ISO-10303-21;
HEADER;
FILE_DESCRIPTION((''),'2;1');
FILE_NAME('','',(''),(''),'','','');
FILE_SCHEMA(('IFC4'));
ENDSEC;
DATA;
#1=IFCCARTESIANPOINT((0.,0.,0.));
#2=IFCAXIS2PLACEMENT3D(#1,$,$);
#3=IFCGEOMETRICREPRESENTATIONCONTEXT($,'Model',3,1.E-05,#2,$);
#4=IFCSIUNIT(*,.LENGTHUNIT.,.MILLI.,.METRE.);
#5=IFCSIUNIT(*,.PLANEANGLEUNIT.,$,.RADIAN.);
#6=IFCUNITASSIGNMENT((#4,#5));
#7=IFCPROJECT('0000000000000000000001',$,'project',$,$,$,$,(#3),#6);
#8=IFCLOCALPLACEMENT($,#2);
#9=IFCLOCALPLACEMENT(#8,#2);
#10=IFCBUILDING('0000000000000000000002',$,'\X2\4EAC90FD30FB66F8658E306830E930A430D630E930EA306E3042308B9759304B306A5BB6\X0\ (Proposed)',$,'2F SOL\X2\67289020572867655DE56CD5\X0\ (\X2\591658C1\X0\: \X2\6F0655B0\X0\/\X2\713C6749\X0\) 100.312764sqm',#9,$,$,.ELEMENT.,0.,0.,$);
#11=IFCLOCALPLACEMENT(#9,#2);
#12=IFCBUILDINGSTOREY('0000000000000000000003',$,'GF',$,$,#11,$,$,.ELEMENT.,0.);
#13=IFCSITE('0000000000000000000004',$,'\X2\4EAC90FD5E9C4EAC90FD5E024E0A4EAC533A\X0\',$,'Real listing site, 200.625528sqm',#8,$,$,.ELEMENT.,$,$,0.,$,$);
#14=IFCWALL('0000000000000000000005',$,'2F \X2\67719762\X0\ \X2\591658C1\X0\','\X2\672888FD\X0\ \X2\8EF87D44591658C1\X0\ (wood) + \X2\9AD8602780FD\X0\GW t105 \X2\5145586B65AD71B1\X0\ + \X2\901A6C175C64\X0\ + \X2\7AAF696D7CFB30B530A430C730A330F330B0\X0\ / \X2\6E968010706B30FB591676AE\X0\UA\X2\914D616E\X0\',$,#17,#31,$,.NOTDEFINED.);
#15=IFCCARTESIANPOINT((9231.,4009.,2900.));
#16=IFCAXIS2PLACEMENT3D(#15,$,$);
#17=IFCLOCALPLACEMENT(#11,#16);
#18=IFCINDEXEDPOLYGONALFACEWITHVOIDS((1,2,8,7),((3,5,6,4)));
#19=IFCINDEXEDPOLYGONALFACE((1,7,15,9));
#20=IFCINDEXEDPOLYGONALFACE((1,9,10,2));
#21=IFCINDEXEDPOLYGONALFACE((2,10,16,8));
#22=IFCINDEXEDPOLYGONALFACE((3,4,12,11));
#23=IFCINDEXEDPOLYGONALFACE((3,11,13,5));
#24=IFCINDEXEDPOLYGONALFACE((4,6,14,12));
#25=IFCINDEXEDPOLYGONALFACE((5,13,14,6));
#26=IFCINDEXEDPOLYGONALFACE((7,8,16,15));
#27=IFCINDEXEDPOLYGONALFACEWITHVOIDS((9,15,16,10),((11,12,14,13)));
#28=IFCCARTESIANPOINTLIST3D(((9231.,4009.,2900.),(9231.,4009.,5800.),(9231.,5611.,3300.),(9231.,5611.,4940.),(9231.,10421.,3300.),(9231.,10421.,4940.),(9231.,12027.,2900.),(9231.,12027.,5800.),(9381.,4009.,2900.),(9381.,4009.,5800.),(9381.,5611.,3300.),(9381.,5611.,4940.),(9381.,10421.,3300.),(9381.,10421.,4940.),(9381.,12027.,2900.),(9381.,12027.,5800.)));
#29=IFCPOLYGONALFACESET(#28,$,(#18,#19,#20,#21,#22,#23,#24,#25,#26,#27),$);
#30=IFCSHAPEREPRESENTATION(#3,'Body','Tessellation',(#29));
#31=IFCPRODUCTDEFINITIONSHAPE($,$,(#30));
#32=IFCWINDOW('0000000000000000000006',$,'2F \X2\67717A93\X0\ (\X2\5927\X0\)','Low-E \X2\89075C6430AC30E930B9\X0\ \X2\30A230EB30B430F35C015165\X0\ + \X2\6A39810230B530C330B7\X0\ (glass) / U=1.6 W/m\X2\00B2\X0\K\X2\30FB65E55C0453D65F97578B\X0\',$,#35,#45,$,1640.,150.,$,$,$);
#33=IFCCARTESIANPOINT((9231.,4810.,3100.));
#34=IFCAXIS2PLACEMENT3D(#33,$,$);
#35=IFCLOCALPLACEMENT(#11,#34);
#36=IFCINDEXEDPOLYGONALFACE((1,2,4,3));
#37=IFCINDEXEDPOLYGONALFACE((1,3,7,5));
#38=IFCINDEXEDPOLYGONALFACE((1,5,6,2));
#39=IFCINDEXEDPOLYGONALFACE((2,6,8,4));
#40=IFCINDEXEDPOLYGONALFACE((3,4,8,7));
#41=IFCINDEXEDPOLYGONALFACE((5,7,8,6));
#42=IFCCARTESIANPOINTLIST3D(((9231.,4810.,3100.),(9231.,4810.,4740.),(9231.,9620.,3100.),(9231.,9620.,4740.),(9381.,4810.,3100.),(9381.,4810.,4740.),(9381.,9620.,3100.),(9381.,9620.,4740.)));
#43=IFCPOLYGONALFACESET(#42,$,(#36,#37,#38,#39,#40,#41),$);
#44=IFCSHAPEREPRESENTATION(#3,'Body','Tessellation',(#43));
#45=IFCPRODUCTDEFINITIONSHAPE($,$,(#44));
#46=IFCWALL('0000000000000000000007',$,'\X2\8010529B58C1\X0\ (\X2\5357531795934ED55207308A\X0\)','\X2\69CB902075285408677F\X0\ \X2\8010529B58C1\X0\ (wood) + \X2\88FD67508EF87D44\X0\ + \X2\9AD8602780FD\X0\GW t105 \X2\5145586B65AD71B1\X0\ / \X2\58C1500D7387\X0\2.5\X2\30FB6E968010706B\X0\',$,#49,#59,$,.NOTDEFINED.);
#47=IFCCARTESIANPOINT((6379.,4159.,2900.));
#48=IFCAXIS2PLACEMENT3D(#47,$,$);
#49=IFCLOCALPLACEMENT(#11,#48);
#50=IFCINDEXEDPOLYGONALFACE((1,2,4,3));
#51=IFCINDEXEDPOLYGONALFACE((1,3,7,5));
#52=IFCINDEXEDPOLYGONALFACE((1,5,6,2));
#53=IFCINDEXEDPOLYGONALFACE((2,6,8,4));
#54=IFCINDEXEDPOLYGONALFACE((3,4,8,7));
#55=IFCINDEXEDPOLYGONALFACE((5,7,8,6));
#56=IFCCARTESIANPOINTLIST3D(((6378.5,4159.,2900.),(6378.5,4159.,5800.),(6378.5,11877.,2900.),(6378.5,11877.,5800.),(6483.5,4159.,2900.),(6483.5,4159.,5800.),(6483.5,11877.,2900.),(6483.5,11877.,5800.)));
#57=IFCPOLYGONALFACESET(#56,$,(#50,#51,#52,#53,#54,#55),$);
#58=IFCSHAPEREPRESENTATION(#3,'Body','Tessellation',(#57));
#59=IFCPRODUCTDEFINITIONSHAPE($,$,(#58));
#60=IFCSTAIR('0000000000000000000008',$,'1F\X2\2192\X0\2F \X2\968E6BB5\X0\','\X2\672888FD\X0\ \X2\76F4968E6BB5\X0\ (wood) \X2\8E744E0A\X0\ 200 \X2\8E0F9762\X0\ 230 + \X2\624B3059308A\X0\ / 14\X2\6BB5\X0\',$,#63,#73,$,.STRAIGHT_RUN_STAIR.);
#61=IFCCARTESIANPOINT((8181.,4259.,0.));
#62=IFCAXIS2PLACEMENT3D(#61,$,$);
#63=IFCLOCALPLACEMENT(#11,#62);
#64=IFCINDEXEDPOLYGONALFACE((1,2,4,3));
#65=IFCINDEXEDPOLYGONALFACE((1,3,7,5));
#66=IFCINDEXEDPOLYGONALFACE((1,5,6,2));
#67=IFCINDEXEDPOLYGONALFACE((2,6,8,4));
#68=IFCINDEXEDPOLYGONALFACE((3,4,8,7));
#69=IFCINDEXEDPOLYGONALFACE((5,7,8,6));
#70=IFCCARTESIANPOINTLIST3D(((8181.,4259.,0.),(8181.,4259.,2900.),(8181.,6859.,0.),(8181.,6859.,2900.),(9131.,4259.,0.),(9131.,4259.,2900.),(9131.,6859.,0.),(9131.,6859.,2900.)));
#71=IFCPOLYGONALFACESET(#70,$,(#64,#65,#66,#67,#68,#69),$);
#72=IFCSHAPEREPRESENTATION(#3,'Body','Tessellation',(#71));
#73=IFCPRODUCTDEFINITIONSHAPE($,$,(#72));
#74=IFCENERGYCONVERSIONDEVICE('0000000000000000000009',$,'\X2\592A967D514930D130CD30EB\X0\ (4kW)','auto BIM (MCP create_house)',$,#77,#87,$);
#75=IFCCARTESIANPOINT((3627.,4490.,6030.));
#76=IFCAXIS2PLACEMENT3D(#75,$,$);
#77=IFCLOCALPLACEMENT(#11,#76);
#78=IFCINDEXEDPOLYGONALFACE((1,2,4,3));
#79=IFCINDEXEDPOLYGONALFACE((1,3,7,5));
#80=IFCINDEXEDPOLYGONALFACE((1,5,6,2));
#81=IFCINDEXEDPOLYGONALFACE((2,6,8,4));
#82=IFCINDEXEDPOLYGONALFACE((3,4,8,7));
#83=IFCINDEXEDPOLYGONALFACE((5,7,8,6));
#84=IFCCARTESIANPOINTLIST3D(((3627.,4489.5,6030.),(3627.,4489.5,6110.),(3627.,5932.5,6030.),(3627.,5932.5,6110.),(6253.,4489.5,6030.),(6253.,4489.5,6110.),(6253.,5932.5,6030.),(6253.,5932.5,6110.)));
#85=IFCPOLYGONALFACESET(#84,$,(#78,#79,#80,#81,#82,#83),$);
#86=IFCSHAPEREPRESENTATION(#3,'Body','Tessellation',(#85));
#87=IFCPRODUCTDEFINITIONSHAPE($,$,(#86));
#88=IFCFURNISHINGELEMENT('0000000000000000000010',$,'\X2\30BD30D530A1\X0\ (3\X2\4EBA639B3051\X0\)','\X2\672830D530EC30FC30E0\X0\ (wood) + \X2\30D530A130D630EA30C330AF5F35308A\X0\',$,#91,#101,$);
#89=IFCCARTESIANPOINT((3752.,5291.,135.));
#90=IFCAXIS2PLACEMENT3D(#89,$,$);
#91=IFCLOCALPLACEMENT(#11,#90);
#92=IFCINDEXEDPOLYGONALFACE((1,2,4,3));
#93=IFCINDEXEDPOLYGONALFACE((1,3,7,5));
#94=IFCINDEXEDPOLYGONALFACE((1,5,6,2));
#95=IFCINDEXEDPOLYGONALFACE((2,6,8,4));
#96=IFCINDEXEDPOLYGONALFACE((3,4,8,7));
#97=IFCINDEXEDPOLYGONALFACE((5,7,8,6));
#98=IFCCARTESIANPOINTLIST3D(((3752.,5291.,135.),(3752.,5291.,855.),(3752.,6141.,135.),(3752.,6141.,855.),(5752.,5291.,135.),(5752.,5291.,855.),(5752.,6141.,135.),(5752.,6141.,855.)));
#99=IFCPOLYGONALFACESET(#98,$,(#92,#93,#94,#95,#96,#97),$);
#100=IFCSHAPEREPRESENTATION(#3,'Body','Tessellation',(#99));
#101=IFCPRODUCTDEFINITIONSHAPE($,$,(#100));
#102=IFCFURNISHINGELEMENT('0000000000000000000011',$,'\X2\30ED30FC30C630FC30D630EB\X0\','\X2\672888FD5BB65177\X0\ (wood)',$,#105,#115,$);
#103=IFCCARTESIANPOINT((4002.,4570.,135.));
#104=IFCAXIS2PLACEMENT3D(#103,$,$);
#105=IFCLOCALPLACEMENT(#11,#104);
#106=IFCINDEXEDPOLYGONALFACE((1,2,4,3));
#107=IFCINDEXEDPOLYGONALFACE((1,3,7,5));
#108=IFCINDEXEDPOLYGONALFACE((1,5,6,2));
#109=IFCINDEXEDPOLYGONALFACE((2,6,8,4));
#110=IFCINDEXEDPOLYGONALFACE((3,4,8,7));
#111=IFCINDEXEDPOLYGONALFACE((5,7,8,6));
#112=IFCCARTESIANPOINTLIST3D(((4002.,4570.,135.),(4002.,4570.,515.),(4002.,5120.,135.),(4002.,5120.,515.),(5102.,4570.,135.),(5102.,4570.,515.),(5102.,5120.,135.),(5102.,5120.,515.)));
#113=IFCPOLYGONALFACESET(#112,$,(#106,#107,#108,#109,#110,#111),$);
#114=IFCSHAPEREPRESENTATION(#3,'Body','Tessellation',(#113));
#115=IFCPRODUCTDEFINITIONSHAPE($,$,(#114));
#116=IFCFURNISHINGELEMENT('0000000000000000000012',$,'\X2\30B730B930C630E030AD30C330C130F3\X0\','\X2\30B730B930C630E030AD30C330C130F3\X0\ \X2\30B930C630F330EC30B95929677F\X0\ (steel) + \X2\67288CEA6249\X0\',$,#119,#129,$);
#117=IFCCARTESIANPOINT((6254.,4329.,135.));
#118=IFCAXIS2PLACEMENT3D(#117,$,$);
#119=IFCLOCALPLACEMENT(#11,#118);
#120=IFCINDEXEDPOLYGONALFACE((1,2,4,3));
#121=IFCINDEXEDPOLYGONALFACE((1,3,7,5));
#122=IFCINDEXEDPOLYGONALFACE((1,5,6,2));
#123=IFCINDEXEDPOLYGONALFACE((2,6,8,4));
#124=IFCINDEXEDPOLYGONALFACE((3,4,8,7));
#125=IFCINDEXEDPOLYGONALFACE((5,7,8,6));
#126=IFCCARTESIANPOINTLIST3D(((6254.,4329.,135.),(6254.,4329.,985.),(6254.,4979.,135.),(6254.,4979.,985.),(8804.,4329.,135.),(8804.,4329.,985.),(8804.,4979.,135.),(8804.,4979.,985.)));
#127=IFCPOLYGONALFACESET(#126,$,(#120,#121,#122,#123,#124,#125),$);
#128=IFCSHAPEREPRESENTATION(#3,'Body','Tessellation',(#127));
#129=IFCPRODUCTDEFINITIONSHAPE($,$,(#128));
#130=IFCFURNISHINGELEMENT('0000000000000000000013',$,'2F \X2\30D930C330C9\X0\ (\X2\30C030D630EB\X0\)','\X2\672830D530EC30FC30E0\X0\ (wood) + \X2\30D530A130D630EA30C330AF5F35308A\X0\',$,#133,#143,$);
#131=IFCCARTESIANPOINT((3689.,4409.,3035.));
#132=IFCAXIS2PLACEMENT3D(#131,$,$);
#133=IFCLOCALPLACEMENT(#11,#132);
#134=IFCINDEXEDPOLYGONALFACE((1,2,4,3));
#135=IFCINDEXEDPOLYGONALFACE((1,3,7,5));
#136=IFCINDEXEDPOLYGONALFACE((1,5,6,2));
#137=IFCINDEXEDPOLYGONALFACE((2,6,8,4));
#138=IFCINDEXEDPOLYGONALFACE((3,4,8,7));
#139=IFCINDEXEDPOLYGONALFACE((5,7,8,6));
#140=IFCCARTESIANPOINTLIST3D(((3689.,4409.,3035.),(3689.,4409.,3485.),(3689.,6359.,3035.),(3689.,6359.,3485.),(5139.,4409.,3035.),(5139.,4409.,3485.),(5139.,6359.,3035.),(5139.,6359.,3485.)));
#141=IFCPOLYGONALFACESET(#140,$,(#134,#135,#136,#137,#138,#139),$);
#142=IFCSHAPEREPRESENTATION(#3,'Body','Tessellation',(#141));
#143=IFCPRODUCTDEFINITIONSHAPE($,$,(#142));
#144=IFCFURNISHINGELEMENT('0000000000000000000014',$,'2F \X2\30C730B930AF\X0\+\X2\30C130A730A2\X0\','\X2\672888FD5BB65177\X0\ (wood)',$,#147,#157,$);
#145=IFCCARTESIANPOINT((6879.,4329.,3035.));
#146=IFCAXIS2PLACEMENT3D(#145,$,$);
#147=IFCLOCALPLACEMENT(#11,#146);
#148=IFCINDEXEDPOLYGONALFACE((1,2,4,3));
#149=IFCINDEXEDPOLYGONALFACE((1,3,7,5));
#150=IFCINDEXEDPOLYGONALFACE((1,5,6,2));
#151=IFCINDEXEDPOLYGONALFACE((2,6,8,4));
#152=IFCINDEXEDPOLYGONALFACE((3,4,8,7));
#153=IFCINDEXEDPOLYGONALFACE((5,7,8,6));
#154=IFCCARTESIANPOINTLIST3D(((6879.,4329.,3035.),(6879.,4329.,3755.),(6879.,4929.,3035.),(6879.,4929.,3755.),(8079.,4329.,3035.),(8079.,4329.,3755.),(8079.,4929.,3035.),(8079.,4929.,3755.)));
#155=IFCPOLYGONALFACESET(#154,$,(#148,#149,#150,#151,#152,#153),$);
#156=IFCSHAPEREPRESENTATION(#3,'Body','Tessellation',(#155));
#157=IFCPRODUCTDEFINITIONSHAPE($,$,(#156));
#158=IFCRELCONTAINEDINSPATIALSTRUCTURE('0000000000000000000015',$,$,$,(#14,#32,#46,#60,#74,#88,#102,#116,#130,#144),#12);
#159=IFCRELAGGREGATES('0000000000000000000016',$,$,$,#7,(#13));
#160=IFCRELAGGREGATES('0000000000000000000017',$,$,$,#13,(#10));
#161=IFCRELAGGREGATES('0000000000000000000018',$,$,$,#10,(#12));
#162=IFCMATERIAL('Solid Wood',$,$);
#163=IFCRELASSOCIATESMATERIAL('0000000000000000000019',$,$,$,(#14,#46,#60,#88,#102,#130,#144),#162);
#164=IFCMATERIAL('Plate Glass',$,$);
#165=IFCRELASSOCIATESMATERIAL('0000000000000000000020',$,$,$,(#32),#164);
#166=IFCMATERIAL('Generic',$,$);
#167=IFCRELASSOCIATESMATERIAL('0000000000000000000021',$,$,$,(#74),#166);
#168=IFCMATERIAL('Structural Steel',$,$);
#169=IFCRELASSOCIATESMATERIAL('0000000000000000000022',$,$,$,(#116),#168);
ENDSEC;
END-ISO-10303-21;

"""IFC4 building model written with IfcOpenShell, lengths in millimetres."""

from ifc_helpers import new_model, si_unit, frame, frame_2d, origin, place, context, project, spatial, rectangle, extrude, material, element, fill, save


model = new_model("IFC4")

# Units and contexts
model_context = context("Model", 3, precision=1e-05, world=origin())
ifc_project = project(units=[si_unit("LENGTHUNIT", "METRE", prefix="MILLI"), si_unit("PLANEANGLEUNIT", "RADIAN")], contexts=[model_context])

# Site, building, storey
site_placement = place(None, origin())
site = spatial("IfcSite", under=ifc_project, at=site_placement, Name="京都府京都市上京区", ObjectType="Real listing site, 200.625528sqm", CompositionType="ELEMENT", RefElevation=0.0)
building_placement = place(site_placement, origin())
building = spatial("IfcBuilding", under=site, at=building_placement, Name="京都・書斎とライブラリのある静かな家 (Proposed)", ObjectType="2F SOL木造在来工法 (外壁: 漆喰/焼杉) 100.312764sqm", CompositionType="ELEMENT", ElevationOfRefHeight=0.0, ElevationOfTerrain=0.0)
storey_placement = place(building_placement, origin())
storey = spatial("IfcBuildingStorey", under=building, at=storey_placement, Name="GF", CompositionType="ELEMENT", Elevation=0.0)

# Shared definitions
ifc_material_1 = material(Name="Solid Wood")
ifc_material_2 = material(Name="Plate Glass")

# Wall, opening, window
wall_1_placement = place(storey_placement, frame((9231.0, 4009.0, 2900.0)))
wall_1 = element("IfcWall", 1, at=wall_1_placement, inside=storey, material=ifc_material_1, Name="2F 東面 外壁", Description="木製 軸組外壁 (wood) + 高性能GW t105 充填断熱 + 通気層 + 窯業系サイディング / 準耐火・外皮UA配慮", PredefinedType="NOTDEFINED", context=model_context, shape_type="SweptSolid", body=[
    extrude(rectangle(XDim=150.0, YDim=8018.0, at=frame_2d((75.0, 4009.0))), frame((9231.0, 4009.0, 2900.0)), (0.0, 0.0, 1.0), 2900.0),
])
opening_1_placement = place(storey_placement, frame((9231.0, 4810.0, 3100.0)))
opening_1 = element("IfcOpeningElement", 2, at=opening_1_placement, cuts=wall_1, PredefinedType="NOTDEFINED", context=model_context, shape_type="SweptSolid", body=[
    extrude(rectangle(XDim=150.0, YDim=4810.0, at=frame_2d((75.0, 2405.0))), frame((9231.0, 4810.0, 3100.0)), (0.0, 0.0, 1.0), 1640.0),
])
window_1_placement = place(storey_placement, frame((9231.0, 4810.0, 3100.0)))
window_1 = element("IfcWindow", 3, at=window_1_placement, inside=storey, material=ifc_material_2, Name="2F 東窓 (大)", Description="Low-E 複層ガラス アルゴン封入 + 樹脂サッシ (glass) / U=1.6 W/m²K・日射取得型", OverallHeight=1640.0, OverallWidth=150.0, context=model_context, shape_type="SweptSolid", body=[
    extrude(rectangle(XDim=150.0, YDim=4810.0, at=frame_2d((75.0, 2405.0))), frame((9231.0, 4810.0, 3100.0)), (0.0, 0.0, 1.0), 1640.0),
])
fill(opening_1, window_1)

# Wall
wall_2_placement = place(storey_placement, frame((6379.0, 4159.0, 2900.0)))
element("IfcWall", 4, at=wall_2_placement, inside=storey, material=ifc_material_1, Name="耐力壁 (南北間仕切り)", Description="構造用合板 耐力壁 (wood) + 製材軸組 + 高性能GW t105 充填断熱 / 壁倍率2.5・準耐火", PredefinedType="NOTDEFINED", context=model_context, shape_type="SweptSolid", body=[
    extrude(rectangle(XDim=105.0, YDim=7718.0, at=frame_2d((52.0, 3859.0))), frame((6379.0, 4159.0, 2900.0)), (0.0, 0.0, 1.0), 2900.0),
])

# Stair
stair_placement = place(storey_placement, frame((8181.0, 4259.0, 0.0)))
element("IfcStair", 5, at=stair_placement, inside=storey, material=ifc_material_1, Name="1F→2F 階段", Description="木製 直階段 (wood) 蹴上 200 踏面 230 + 手すり / 14段", PredefinedType="STRAIGHT_RUN_STAIR", context=model_context, shape_type="SweptSolid", body=[
    extrude(rectangle(XDim=950.0, YDim=2600.0, at=frame_2d((475.0, 1300.0))), frame((8181.0, 4259.0, 0.0)), (0.0, 0.0, 1.0), 2900.0),
])

# Energy conversion device
ifc_material_3 = material(Name="Generic")
energy_conversion_device_placement = place(storey_placement, frame((3627.0, 4490.0, 6030.0)))
element("IfcEnergyConversionDevice", 6, at=energy_conversion_device_placement, inside=storey, material=ifc_material_3, Name="太陽光パネル (4kW)", Description="auto BIM (MCP create_house)", context=model_context, shape_type="SweptSolid", body=[
    extrude(rectangle(XDim=2626.0, YDim=1443.0, at=frame_2d((1313.0, 721.0))), frame((3627.0, 4490.0, 6030.0)), (0.0, 0.0, 1.0), 80.0),
])

# Furnishing elements
furnishing_1_placement = place(storey_placement, frame((3752.0, 5291.0, 135.0)))
element("IfcFurnishingElement", 7, at=furnishing_1_placement, inside=storey, material=ifc_material_1, Name="ソファ (3人掛け)", Description="木フレーム (wood) + ファブリック張り", context=model_context, shape_type="SweptSolid", body=[
    extrude(rectangle(XDim=2000.0, YDim=850.0, at=frame_2d((1000.0, 425.0))), frame((3752.0, 5291.0, 135.0)), (0.0, 0.0, 1.0), 720.0),
])
furnishing_2_placement = place(storey_placement, frame((4002.0, 4570.0, 135.0)))
element("IfcFurnishingElement", 8, at=furnishing_2_placement, inside=storey, material=ifc_material_1, Name="ローテーブル", Description="木製家具 (wood)", context=model_context, shape_type="SweptSolid", body=[
    extrude(rectangle(XDim=1100.0, YDim=550.0, at=frame_2d((550.0, 275.0))), frame((4002.0, 4570.0, 135.0)), (0.0, 0.0, 1.0), 380.0),
])
ifc_material_4 = material(Name="Structural Steel")
furnishing_3_placement = place(storey_placement, frame((6254.0, 4329.0, 135.0)))
element("IfcFurnishingElement", 9, at=furnishing_3_placement, inside=storey, material=ifc_material_4, Name="システムキッチン", Description="システムキッチン ステンレス天板 (steel) + 木質扉", context=model_context, shape_type="SweptSolid", body=[
    extrude(rectangle(XDim=2550.0, YDim=650.0, at=frame_2d((1275.0, 325.0))), frame((6254.0, 4329.0, 135.0)), (0.0, 0.0, 1.0), 850.0),
])
furnishing_4_placement = place(storey_placement, frame((3689.0, 4409.0, 3035.0)))
element("IfcFurnishingElement", 10, at=furnishing_4_placement, inside=storey, material=ifc_material_1, Name="2F ベッド (ダブル)", Description="木フレーム (wood) + ファブリック張り", context=model_context, shape_type="SweptSolid", body=[
    extrude(rectangle(XDim=1450.0, YDim=1950.0, at=frame_2d((725.0, 975.0))), frame((3689.0, 4409.0, 3035.0)), (0.0, 0.0, 1.0), 450.0),
])
furnishing_5_placement = place(storey_placement, frame((6879.0, 4329.0, 3035.0)))
element("IfcFurnishingElement", 11, at=furnishing_5_placement, inside=storey, material=ifc_material_1, Name="2F デスク+チェア", Description="木製家具 (wood)", context=model_context, shape_type="SweptSolid", body=[
    extrude(rectangle(XDim=1200.0, YDim=600.0, at=frame_2d((600.0, 300.0))), frame((6879.0, 4329.0, 3035.0)), (0.0, 0.0, 1.0), 720.0),
])

save(model, "model.ifc")
